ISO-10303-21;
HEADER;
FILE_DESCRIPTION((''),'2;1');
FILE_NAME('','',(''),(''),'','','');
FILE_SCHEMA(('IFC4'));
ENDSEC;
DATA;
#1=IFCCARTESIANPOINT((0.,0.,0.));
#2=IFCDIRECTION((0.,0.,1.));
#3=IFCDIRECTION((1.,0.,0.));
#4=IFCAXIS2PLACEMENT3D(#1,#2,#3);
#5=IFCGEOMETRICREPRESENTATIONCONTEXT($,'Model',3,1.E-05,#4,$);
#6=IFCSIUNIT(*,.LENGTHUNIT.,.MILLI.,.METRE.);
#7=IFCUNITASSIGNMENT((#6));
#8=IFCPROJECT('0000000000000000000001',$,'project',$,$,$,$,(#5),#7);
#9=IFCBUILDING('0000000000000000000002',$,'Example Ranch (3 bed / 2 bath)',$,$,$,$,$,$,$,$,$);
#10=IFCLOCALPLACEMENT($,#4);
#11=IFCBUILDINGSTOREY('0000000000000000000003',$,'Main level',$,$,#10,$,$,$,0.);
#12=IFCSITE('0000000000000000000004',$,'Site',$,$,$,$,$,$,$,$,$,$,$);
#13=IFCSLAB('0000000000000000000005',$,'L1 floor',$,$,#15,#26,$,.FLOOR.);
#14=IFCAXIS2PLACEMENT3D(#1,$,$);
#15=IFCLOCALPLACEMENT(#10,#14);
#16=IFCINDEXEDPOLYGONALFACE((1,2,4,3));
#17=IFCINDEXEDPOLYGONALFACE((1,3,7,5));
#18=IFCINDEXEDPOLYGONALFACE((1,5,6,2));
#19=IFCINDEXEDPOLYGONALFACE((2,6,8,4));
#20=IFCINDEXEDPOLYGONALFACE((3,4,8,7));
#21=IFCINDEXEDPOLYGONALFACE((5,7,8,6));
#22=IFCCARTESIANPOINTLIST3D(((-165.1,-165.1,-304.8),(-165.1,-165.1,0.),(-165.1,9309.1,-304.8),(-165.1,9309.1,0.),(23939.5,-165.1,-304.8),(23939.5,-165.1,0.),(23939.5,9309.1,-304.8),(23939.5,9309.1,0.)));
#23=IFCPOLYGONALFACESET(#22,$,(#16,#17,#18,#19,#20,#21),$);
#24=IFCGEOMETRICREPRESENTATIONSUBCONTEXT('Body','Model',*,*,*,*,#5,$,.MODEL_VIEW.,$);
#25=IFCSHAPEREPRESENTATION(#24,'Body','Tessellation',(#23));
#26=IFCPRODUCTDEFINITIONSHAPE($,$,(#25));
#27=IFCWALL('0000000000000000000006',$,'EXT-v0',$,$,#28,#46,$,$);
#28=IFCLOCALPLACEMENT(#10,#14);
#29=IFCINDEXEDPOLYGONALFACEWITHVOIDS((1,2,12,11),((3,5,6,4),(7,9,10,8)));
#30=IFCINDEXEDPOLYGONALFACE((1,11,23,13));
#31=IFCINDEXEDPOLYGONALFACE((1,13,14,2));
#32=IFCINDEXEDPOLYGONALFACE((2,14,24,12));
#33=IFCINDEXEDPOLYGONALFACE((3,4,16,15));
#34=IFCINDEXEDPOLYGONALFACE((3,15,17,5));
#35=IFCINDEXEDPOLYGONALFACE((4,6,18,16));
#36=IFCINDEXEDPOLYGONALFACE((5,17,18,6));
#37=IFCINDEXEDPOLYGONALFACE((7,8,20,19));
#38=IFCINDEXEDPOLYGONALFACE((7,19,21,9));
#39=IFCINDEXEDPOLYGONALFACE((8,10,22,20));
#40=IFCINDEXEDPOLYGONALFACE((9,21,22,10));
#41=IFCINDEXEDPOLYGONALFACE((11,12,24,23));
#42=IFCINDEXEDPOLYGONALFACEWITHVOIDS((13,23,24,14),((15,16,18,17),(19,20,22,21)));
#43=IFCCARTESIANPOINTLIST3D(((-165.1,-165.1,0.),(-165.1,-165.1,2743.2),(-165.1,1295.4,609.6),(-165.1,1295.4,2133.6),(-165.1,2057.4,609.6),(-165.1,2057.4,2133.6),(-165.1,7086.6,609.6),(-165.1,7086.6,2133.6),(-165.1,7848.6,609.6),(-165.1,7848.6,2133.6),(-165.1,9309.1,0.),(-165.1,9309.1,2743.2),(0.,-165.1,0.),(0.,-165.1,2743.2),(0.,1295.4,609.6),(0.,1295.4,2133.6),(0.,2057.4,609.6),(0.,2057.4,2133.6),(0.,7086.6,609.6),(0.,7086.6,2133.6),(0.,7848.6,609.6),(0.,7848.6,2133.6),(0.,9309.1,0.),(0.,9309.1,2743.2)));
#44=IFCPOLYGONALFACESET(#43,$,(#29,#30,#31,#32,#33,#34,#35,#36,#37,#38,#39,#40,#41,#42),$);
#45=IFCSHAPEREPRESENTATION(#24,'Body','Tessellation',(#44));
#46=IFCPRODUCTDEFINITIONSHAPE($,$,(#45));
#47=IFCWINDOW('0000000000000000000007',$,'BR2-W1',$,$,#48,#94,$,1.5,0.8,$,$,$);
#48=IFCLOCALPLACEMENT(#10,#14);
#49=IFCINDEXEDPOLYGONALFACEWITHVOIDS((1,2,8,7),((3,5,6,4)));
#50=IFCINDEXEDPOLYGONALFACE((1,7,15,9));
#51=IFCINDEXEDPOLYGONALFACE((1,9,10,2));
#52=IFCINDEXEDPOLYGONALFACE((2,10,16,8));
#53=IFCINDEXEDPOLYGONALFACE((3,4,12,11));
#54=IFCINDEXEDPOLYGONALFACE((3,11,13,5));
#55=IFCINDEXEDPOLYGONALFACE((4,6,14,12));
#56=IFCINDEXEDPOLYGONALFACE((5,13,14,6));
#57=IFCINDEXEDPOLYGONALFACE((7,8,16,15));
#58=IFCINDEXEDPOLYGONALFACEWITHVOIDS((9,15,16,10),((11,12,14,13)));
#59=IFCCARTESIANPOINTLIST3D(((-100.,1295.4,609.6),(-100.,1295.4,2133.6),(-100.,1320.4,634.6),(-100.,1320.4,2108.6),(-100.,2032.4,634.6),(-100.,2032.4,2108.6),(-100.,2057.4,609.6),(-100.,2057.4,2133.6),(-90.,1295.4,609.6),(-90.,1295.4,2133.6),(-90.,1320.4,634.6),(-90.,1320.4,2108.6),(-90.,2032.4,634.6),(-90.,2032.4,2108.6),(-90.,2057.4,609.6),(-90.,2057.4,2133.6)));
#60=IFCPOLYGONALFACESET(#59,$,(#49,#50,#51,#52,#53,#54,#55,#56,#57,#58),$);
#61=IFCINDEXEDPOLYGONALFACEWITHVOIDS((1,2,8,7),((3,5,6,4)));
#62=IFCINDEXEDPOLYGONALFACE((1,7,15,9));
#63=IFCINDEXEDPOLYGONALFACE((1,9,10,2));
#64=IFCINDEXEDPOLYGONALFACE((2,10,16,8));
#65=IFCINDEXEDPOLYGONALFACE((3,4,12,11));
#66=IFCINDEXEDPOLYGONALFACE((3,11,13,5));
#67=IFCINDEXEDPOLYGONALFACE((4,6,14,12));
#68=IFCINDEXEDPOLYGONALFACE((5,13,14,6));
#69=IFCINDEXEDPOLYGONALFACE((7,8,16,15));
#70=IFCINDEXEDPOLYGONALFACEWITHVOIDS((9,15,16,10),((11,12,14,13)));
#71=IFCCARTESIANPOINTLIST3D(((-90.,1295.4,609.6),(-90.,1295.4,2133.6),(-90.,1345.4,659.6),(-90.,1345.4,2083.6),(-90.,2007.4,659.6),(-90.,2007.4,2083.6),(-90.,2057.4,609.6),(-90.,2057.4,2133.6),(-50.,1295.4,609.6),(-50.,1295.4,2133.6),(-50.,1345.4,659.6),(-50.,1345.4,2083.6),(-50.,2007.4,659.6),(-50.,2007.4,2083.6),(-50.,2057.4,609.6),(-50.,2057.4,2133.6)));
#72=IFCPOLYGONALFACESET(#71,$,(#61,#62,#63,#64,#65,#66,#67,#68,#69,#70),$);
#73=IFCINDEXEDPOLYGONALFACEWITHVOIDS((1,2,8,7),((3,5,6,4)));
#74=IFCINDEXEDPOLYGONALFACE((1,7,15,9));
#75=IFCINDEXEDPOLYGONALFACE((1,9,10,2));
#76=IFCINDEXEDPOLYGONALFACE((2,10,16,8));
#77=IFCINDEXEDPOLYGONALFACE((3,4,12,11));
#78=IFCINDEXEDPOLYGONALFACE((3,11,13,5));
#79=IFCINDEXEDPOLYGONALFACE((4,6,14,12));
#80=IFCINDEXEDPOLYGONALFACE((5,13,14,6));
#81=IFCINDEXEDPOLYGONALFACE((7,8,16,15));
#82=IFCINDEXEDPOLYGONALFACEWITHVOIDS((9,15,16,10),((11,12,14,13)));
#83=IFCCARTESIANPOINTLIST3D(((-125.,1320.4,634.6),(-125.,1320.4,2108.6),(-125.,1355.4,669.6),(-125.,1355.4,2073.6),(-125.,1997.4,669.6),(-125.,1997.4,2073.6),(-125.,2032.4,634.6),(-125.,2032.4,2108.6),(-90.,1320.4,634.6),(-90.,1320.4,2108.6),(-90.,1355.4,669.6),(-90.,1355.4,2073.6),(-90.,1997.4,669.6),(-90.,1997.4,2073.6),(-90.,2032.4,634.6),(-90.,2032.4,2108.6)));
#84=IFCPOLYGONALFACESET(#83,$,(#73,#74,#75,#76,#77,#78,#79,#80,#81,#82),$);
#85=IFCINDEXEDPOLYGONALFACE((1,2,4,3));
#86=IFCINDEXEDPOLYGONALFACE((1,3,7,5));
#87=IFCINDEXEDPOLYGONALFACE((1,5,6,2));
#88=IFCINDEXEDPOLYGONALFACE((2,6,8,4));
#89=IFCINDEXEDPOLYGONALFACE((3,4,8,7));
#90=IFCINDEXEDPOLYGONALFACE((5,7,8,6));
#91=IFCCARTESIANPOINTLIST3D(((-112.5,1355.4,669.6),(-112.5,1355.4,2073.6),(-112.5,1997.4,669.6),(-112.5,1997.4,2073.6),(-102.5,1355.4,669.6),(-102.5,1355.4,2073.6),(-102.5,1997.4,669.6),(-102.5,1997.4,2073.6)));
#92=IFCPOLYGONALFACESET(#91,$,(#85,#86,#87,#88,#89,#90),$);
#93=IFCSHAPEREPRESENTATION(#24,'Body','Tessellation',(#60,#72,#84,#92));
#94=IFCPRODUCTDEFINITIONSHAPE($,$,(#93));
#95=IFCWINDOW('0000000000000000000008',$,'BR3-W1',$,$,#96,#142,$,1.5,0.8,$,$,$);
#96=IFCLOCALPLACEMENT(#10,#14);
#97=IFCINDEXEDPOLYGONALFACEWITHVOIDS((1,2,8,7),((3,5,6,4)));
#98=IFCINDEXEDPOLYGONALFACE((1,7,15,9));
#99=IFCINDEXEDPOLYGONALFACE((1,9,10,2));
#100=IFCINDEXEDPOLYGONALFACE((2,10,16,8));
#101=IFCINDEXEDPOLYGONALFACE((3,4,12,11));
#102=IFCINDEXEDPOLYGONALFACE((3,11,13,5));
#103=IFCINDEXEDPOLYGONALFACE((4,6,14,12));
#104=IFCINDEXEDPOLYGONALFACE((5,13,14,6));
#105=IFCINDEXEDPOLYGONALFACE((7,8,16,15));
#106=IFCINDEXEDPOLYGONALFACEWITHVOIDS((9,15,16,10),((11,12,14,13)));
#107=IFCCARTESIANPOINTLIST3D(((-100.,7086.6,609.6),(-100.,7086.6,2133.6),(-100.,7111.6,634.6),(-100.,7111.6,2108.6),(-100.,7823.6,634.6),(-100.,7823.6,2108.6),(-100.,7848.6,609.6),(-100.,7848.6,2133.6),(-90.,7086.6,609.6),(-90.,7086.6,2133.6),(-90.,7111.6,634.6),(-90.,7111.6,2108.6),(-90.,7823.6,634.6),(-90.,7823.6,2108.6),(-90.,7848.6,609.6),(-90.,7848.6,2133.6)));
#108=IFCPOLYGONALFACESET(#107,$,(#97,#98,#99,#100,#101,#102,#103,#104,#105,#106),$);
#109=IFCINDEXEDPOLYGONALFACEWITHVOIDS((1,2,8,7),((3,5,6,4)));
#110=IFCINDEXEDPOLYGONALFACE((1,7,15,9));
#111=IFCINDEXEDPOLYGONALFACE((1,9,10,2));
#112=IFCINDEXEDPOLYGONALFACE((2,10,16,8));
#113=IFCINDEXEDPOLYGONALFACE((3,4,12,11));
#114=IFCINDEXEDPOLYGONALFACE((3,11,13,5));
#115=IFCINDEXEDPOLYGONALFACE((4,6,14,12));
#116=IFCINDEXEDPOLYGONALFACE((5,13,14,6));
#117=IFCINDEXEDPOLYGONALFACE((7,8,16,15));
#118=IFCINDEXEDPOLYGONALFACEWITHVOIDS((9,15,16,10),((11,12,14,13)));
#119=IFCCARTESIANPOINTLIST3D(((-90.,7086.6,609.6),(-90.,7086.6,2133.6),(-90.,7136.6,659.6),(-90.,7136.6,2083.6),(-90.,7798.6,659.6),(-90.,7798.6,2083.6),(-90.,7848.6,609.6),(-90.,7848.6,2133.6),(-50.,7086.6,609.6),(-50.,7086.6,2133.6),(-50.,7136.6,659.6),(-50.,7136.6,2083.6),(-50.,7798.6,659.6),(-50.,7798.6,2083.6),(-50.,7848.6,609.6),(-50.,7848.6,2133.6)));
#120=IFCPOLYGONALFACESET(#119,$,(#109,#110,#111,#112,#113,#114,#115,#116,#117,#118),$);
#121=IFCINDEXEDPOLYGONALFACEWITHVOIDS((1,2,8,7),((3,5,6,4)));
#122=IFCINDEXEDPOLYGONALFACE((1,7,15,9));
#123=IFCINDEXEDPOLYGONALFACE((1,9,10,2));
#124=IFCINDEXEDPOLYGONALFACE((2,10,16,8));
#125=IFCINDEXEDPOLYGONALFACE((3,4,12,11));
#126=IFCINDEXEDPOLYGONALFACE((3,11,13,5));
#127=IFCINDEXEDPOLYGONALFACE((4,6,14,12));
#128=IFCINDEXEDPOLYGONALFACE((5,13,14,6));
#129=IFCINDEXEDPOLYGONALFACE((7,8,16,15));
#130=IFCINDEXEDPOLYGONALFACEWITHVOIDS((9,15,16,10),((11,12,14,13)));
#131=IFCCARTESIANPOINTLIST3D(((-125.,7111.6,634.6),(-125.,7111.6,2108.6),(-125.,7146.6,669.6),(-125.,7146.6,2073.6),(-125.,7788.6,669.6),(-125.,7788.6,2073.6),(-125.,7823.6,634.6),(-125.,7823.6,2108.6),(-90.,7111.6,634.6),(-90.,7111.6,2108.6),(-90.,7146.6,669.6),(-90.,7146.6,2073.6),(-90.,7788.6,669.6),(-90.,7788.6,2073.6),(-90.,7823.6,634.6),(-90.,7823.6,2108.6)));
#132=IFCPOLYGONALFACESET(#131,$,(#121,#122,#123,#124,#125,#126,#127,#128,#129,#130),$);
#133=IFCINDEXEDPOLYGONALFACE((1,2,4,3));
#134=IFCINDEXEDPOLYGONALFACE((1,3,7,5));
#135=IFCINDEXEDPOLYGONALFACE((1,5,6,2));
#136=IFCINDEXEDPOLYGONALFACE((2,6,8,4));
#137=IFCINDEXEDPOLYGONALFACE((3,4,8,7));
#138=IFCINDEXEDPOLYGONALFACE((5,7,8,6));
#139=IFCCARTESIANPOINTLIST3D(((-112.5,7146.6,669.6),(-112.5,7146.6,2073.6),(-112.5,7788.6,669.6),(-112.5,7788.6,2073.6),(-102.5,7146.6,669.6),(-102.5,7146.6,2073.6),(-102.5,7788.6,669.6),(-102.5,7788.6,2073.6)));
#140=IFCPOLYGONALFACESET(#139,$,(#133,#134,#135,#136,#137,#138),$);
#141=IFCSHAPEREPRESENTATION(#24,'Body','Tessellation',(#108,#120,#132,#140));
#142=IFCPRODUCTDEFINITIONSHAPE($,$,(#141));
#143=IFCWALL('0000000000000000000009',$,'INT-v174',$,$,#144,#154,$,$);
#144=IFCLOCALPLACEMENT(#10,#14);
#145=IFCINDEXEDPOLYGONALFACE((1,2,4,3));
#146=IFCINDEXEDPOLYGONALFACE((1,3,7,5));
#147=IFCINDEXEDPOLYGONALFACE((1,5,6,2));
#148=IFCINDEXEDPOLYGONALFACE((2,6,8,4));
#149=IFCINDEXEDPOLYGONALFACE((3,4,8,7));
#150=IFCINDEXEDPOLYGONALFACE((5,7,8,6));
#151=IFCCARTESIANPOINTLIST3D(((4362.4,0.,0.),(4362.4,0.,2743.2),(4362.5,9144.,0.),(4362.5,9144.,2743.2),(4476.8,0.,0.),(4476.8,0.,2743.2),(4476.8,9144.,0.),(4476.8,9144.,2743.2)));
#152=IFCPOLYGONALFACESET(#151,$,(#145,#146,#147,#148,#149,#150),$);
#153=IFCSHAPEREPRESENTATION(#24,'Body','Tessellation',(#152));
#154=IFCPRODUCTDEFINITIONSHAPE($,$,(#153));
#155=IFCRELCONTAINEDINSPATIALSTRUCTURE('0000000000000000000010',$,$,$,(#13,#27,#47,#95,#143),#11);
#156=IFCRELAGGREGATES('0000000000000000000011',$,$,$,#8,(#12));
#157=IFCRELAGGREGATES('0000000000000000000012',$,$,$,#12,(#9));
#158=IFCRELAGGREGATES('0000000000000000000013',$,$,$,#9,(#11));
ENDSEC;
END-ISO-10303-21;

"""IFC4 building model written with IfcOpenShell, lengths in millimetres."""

from ifc_helpers import new_model, si_unit, frame, origin_with_axes, place, context, subcontext, project, spatial, line, indexed_curve, outline, extrude, element, fill, save


model = new_model("IFC4")

# Units and contexts
model_context = context("Model", 3, precision=1e-05, world=origin_with_axes())
body_context = subcontext(model_context, "Body", "Model", "MODEL_VIEW")
ifc_project = project(units=[si_unit("LENGTHUNIT", "METRE", prefix="MILLI")], contexts=[model_context])

# Site, building, storey
site = spatial("IfcSite", under=ifc_project, Name="Site")
building = spatial("IfcBuilding", under=site, Name="Example Ranch (3 bed / 2 bath)")
storey_placement = place(None, origin_with_axes())
storey = spatial("IfcBuildingStorey", under=building, at=storey_placement, Name="Main level", Elevation=0.0)

# Slab
slab_placement = place(storey_placement, frame((-165.1, -165.1, -304.8), z_axis=(0.0, 0.0, 1.0), x_axis=(1.0, 0.0, 0.0)))
element("IfcSlab", 1, at=slab_placement, inside=storey, Name="L1 floor", PredefinedType="FLOOR", context=body_context, shape_type="SweptSolid", body=[
    extrude(outline(indexed_curve([(0.0, 0.0), (24104.6, 0.0), (24104.6, 9474.2), (0.0, 9474.2), (0.0, 0.0)])), None, (0.0, 0.0, 1.0), 304.8),
])

# Wall, openings, windows
wall_1_placement = place(storey_placement, frame((0.0, -165.1, 0.0), z_axis=(0.0, 0.0, 1.0), x_axis=(0.0, 1.0, 0.0)))
wall_1 = element("IfcWall", 2, at=wall_1_placement, inside=storey, Name="EXT-v0", context=body_context, shape_type="SweptSolid", body=[
    extrude(outline(indexed_curve([(0.0, 0.0), (0.0, 165.1), (9474.2, 165.1), (9474.2, 0.0), (0.0, 0.0)], self_intersect=False)), origin_with_axes(), (0.0, 0.0, 1.0), 2743.2),
])
opening_1_placement = place(wall_1_placement, frame((1460.5, 0.0, 609.6), z_axis=(0.0, 0.0, 1.0), x_axis=(1.0, 0.0, 0.0)))
opening_1 = element("IfcOpeningElement", 3, at=opening_1_placement, cuts=wall_1, context=body_context, shape_type="SweptSolid", body=[
    extrude(outline(indexed_curve([(0.0, 0.0), (0.0, 165.1), (762.0, 165.1), (762.0, 0.0), (0.0, 0.0)], self_intersect=False)), origin_with_axes(), (0.0, 0.0, 1.0), 1524.0),
])
opening_2_placement = place(wall_1_placement, frame((7251.7, 0.0, 609.6), z_axis=(0.0, 0.0, 1.0), x_axis=(1.0, 0.0, 0.0)))
opening_2 = element("IfcOpeningElement", 4, at=opening_2_placement, cuts=wall_1, context=body_context, shape_type="SweptSolid", body=[
    extrude(outline(indexed_curve([(0.0, 0.0), (0.0, 165.1), (762.0, 165.1), (762.0, 0.0), (0.0, 0.0)], self_intersect=False)), origin_with_axes(), (0.0, 0.0, 1.0), 1524.0),
])
window_1_placement = place(storey_placement, frame((0.0, 1295.4, 609.6), z_axis=(0.0, 0.0, 1.0), x_axis=(0.0, 1.0, 0.0)))
window_1 = element("IfcWindow", 5, at=window_1_placement, inside=storey, Name="BR2-W1", OverallHeight=1.5, OverallWidth=0.8, context=body_context, shape_type="SweptSolid", body=[
    extrude(outline(indexed_curve([(0.0, 0.0), (762.0, 0.0), (762.0, 1524.0), (0.0, 1524.0)], segments=[line(1, 2, 3, 4, 1)]), holes=[indexed_curve([(25.0, 25.0), (737.0, 25.0), (737.0, 1499.0), (25.0, 1499.0)], segments=[line(1, 2, 3, 4, 1)])]), frame((0.0, 90.0, 0.0), z_axis=(0.0, -1.0, 0.0), x_axis=(1.0, 0.0, 0.0)), (0.0, 0.0, -1.0), 10.0),
    extrude(outline(indexed_curve([(0.0, 0.0), (762.0, 0.0), (762.0, 1524.0), (0.0, 1524.0)], segments=[line(1, 2, 3, 4, 1)]), holes=[indexed_curve([(50.0, 50.0), (712.0, 50.0), (712.0, 1474.0), (50.0, 1474.0)], segments=[line(1, 2, 3, 4, 1)])]), frame((0.0, 50.0, 0.0), z_axis=(0.0, -1.0, 0.0), x_axis=(1.0, 0.0, 0.0)), (0.0, 0.0, -1.0), 40.0),
    extrude(outline(indexed_curve([(0.0, 0.0), (712.0, 0.0), (712.0, 1474.0), (0.0, 1474.0)], segments=[line(1, 2, 3, 4, 1)]), holes=[indexed_curve([(35.0, 35.0), (677.0, 35.0), (677.0, 1439.0), (35.0, 1439.0)], segments=[line(1, 2, 3, 4, 1)])]), frame((25.0, 90.0, 25.0), z_axis=(0.0, -1.0, 0.0), x_axis=(1.0, 0.0, 0.0)), (0.0, 0.0, -1.0), 35.0),
    extrude(outline(indexed_curve([(35.0, 35.0), (677.0, 35.0), (677.0, 1439.0), (35.0, 1439.0)], segments=[line(1, 2, 3, 4, 1)])), frame((25.0, 102.5, 25.0), z_axis=(0.0, -1.0, 0.0), x_axis=(1.0, 0.0, 0.0)), (0.0, 0.0, -1.0), 10.0),
])
fill(opening_1, window_1)
window_2_placement = place(storey_placement, frame((0.0, 7086.6, 609.6), z_axis=(0.0, 0.0, 1.0), x_axis=(0.0, 1.0, 0.0)))
window_2 = element("IfcWindow", 6, at=window_2_placement, inside=storey, Name="BR3-W1", OverallHeight=1.5, OverallWidth=0.8, context=body_context, shape_type="SweptSolid", body=[
    extrude(outline(indexed_curve([(0.0, 0.0), (762.0, 0.0), (762.0, 1524.0), (0.0, 1524.0)], segments=[line(1, 2, 3, 4, 1)]), holes=[indexed_curve([(25.0, 25.0), (737.0, 25.0), (737.0, 1499.0), (25.0, 1499.0)], segments=[line(1, 2, 3, 4, 1)])]), frame((0.0, 90.0, 0.0), z_axis=(0.0, -1.0, 0.0), x_axis=(1.0, 0.0, 0.0)), (0.0, 0.0, -1.0), 10.0),
    extrude(outline(indexed_curve([(0.0, 0.0), (762.0, 0.0), (762.0, 1524.0), (0.0, 1524.0)], segments=[line(1, 2, 3, 4, 1)]), holes=[indexed_curve([(50.0, 50.0), (712.0, 50.0), (712.0, 1474.0), (50.0, 1474.0)], segments=[line(1, 2, 3, 4, 1)])]), frame((0.0, 50.0, 0.0), z_axis=(0.0, -1.0, 0.0), x_axis=(1.0, 0.0, 0.0)), (0.0, 0.0, -1.0), 40.0),
    extrude(outline(indexed_curve([(0.0, 0.0), (712.0, 0.0), (712.0, 1474.0), (0.0, 1474.0)], segments=[line(1, 2, 3, 4, 1)]), holes=[indexed_curve([(35.0, 35.0), (677.0, 35.0), (677.0, 1439.0), (35.0, 1439.0)], segments=[line(1, 2, 3, 4, 1)])]), frame((25.0, 90.0, 25.0), z_axis=(0.0, -1.0, 0.0), x_axis=(1.0, 0.0, 0.0)), (0.0, 0.0, -1.0), 35.0),
    extrude(outline(indexed_curve([(35.0, 35.0), (677.0, 35.0), (677.0, 1439.0), (35.0, 1439.0)], segments=[line(1, 2, 3, 4, 1)])), frame((25.0, 102.5, 25.0), z_axis=(0.0, -1.0, 0.0), x_axis=(1.0, 0.0, 0.0)), (0.0, 0.0, -1.0), 10.0),
])
fill(opening_2, window_2)

# Wall
wall_2_placement = place(storey_placement, frame((4476.8, 0.0, 0.0), z_axis=(0.0, 0.0, 1.0), x_axis=(0.0, 1.0, 0.0)))
element("IfcWall", 7, at=wall_2_placement, inside=storey, Name="INT-v174", context=body_context, shape_type="SweptSolid", body=[
    extrude(outline(indexed_curve([(0.0, 0.0), (0.0, 114.3), (9144.0, 114.3), (9144.0, 0.0), (0.0, 0.0)], self_intersect=False)), origin_with_axes(), (0.0, 0.0, 1.0), 2743.2),
])

save(model, "model.ifc")
